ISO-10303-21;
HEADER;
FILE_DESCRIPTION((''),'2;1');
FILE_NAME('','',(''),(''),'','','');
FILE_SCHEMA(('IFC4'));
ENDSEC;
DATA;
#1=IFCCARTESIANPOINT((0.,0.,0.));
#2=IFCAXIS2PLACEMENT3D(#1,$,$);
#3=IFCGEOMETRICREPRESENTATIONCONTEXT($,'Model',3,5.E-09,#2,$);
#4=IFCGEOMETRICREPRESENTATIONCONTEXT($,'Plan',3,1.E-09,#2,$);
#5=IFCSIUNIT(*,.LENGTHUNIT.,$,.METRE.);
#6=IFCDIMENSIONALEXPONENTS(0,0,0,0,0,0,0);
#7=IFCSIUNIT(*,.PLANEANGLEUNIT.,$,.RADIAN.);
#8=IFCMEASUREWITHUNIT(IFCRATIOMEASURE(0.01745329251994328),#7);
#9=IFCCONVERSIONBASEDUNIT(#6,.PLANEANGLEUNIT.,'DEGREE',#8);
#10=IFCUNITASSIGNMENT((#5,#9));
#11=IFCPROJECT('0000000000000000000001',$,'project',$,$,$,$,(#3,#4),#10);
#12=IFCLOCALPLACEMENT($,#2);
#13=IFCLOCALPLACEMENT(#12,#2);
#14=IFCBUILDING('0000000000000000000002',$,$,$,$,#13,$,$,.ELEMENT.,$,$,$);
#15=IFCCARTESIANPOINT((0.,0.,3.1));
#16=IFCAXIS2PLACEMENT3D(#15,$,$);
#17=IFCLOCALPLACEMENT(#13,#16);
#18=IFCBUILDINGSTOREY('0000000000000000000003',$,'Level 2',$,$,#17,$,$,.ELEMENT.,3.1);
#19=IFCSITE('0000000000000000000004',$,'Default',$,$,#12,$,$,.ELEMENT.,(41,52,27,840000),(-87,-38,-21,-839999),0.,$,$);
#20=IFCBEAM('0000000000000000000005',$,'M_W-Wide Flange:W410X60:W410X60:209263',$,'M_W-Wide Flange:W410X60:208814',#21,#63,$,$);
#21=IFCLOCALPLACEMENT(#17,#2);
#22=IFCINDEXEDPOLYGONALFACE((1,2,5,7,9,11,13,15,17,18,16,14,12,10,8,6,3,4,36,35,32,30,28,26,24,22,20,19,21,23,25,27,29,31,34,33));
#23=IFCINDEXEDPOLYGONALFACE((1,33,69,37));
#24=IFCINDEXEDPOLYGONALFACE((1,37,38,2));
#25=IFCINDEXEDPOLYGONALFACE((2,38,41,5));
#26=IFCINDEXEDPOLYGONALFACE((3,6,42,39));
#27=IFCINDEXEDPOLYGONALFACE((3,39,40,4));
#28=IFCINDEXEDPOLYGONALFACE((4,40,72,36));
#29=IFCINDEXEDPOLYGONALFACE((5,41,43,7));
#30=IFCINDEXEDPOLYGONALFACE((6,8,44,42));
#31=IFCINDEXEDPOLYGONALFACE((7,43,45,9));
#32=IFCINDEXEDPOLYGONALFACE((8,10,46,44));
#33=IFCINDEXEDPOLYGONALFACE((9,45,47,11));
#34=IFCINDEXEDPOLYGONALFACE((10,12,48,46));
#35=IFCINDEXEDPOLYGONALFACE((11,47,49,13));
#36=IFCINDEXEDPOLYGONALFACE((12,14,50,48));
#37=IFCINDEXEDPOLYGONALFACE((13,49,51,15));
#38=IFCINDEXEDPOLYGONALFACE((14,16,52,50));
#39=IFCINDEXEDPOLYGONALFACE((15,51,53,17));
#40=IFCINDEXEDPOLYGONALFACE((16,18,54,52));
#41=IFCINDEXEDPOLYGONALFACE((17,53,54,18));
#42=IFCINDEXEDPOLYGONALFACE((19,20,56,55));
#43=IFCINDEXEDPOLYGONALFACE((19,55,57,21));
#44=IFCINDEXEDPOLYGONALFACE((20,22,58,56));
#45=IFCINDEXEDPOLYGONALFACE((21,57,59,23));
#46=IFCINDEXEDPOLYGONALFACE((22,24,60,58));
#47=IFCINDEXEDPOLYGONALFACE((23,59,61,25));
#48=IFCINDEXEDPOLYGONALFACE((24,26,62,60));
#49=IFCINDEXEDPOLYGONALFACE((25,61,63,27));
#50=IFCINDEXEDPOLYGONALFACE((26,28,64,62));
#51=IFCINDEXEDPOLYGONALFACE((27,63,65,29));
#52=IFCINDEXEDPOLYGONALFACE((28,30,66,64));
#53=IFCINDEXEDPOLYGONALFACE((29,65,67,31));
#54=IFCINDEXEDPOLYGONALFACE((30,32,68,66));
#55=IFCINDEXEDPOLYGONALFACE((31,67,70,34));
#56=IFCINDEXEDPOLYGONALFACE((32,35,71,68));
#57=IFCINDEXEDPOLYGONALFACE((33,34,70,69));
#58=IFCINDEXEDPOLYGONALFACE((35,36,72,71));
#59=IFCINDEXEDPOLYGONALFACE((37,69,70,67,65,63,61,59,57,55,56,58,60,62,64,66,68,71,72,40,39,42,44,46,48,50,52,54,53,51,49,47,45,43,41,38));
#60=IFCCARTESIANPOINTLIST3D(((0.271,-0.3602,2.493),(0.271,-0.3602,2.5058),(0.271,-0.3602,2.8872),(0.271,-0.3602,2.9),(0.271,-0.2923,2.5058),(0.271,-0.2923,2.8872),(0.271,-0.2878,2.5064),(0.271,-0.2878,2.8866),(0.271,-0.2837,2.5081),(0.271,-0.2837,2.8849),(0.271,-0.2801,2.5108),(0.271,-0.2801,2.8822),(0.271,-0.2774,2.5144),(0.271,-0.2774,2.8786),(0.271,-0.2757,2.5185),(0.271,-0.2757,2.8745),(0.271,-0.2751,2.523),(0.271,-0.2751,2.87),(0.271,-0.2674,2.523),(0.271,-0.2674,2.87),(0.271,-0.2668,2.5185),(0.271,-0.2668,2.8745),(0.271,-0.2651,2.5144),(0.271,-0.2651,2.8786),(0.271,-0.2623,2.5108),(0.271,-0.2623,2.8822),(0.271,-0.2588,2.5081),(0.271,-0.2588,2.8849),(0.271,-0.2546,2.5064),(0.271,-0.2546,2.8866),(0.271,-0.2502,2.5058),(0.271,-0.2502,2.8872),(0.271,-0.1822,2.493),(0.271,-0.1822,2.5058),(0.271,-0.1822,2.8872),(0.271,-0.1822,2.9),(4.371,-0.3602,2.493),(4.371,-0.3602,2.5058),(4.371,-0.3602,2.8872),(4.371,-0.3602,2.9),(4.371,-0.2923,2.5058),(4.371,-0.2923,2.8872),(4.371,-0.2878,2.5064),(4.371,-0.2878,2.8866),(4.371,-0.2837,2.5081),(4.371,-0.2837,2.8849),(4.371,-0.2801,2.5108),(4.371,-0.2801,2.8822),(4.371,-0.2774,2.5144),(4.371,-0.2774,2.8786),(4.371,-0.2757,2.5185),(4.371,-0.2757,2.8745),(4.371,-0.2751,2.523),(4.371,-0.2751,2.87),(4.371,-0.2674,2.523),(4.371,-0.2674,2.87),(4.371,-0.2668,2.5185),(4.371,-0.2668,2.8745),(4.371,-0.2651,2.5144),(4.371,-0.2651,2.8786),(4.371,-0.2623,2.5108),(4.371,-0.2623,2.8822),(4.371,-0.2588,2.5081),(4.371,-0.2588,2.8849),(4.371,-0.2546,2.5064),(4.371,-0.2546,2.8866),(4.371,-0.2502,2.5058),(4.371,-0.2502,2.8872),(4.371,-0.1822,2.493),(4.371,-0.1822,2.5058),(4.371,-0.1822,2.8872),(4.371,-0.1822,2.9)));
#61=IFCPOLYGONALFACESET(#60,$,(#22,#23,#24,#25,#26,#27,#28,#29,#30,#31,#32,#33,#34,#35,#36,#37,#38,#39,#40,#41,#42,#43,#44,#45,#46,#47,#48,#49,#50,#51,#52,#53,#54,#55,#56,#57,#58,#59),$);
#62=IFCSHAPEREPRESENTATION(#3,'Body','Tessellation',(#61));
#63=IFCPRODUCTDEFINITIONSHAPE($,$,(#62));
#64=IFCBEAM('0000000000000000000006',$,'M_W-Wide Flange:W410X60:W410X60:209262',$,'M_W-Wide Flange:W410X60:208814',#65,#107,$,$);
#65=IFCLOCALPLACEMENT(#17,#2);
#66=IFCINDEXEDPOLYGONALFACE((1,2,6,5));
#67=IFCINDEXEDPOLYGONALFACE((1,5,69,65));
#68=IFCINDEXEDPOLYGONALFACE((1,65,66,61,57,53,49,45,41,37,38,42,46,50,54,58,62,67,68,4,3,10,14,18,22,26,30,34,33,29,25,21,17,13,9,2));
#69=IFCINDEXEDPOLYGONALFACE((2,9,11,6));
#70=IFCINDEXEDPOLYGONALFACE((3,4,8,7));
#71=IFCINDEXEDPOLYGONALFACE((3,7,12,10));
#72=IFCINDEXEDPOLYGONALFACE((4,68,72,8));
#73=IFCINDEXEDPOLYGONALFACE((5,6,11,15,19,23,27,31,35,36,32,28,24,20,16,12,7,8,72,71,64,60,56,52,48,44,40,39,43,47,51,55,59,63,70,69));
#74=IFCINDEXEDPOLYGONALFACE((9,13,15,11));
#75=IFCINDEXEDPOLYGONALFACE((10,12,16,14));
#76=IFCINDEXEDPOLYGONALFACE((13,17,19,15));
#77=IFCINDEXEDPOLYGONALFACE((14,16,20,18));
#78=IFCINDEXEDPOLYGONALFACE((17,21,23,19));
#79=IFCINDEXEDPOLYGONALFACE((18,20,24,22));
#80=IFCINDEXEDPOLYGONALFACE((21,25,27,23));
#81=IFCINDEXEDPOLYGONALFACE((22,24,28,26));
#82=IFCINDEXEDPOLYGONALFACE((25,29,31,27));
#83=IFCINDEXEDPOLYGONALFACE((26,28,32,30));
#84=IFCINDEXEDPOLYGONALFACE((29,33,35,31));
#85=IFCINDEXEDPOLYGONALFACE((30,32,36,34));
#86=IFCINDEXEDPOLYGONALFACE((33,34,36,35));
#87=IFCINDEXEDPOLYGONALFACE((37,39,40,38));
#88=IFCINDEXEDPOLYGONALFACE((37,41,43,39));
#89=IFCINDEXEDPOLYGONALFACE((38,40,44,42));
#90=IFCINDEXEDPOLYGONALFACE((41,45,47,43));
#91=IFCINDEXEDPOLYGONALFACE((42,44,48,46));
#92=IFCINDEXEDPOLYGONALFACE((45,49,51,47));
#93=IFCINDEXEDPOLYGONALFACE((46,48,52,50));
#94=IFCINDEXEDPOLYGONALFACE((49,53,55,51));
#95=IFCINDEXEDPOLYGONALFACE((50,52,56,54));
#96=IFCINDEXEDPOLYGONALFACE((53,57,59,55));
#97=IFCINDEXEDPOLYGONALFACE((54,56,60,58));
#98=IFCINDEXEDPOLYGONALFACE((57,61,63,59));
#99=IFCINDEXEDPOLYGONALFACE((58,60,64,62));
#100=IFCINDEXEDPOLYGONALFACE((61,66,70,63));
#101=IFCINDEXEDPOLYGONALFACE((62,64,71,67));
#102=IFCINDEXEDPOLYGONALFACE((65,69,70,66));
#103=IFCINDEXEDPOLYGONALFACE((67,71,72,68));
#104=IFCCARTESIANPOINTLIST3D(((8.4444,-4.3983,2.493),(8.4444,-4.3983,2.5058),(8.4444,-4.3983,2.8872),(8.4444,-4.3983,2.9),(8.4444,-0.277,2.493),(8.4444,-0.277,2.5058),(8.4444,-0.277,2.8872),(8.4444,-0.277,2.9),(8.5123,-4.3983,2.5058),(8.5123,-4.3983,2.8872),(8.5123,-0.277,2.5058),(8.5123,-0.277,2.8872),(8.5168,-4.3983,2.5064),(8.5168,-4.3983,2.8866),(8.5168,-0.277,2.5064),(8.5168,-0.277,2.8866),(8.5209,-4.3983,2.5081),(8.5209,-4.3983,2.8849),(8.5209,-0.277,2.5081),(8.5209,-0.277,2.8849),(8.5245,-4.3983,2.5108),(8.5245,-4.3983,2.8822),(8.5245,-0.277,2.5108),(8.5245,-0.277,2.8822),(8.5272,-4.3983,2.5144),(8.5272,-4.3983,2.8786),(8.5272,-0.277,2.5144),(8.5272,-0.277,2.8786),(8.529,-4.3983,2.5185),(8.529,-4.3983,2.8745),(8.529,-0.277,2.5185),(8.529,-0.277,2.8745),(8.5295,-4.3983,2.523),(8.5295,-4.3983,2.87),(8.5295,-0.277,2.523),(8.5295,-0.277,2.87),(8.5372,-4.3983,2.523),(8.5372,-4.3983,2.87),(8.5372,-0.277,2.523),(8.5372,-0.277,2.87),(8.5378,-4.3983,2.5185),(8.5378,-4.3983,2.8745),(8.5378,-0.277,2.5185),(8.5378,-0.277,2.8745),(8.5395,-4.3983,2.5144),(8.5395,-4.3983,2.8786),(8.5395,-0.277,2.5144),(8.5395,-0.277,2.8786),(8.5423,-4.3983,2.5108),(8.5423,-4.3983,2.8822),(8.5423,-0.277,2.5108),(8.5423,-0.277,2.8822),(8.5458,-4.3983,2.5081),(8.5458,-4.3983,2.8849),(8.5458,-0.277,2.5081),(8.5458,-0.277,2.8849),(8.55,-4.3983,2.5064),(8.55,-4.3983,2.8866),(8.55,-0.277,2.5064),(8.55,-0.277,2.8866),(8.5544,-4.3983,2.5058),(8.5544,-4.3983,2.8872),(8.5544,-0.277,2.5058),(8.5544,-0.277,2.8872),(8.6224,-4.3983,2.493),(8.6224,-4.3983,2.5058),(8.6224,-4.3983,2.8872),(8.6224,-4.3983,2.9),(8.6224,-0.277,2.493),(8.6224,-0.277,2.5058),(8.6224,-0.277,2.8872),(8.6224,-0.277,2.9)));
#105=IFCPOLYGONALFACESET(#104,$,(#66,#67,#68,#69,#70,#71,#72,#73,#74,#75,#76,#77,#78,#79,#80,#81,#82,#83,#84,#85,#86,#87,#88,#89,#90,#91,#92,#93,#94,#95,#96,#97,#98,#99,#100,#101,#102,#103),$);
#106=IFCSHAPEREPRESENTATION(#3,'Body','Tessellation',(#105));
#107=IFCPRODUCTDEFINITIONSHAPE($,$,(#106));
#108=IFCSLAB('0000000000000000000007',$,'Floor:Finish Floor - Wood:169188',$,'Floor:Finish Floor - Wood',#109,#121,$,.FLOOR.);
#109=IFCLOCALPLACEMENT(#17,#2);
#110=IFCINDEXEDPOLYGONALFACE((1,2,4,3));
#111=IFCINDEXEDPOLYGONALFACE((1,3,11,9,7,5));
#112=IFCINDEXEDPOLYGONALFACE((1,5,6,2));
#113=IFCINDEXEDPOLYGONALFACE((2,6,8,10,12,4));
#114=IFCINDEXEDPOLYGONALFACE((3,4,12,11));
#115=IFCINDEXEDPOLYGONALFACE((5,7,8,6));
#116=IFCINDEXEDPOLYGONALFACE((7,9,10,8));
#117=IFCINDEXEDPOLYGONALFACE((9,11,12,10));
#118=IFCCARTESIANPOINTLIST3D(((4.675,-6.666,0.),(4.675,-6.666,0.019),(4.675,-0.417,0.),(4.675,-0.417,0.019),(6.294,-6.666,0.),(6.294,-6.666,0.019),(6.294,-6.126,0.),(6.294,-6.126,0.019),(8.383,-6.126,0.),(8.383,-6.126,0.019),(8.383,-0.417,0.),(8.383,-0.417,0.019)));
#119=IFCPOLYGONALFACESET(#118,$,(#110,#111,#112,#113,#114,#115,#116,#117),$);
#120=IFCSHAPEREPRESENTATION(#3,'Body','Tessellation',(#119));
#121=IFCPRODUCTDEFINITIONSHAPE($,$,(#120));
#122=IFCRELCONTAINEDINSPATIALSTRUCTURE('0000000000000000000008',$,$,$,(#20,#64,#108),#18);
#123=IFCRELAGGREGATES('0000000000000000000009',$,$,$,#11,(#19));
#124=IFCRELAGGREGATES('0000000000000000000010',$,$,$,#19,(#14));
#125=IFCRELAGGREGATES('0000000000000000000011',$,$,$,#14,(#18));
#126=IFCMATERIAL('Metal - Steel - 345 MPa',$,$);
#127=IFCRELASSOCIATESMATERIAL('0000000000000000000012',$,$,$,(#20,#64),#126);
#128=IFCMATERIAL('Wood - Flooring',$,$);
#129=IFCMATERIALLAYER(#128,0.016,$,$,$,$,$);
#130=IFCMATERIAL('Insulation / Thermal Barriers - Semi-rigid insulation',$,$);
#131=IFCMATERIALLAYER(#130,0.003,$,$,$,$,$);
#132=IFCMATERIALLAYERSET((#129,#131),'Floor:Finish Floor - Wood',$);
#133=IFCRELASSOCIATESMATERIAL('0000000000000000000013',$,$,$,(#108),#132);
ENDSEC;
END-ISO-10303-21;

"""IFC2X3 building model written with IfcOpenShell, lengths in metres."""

from ifc_helpers import new_model, entity, si_unit, converted_unit, frame, frame_2d, origin, place, context, project, spatial, polyline, circle_curve, parameter, trimmed, segment, composite_curve, outline, extrude, material, layer, layer_set, layer_usage, element, save


model = new_model("IFC2X3")

# Units and contexts
model_context = context("Model", 3, precision=5e-09, world=origin())
plan_context = context("Plan", 3, precision=1e-09, world=origin())
ifc_project = project(units=[si_unit("LENGTHUNIT", "METRE"), converted_unit("PLANEANGLEUNIT", "DEGREE", entity("IfcRatioMeasure", 0.01745329251994328), si_unit("PLANEANGLEUNIT", "RADIAN"), dimensions=[0, 0, 0, 0, 0, 0, 0])], contexts=[model_context, plan_context])

# Site, building, storey
site_placement = place(None, origin())
site = spatial("IfcSite", under=ifc_project, at=site_placement, Name="Default", CompositionType="ELEMENT", RefLatitude=(41, 52, 27, 840000), RefLongitude=(-87, -38, -21, -839999), RefElevation=0.0)
building_placement = place(site_placement, origin())
building = spatial("IfcBuilding", under=site, at=building_placement, CompositionType="ELEMENT")
storey_placement = place(building_placement, frame((0.0, 0.0, 3.1)))
storey = spatial("IfcBuildingStorey", under=building, at=storey_placement, Name="Level 2", CompositionType="ELEMENT", Elevation=3.1)

# Beams
ifc_material_1 = material(Name="Metal - Steel - 345 MPa")
beam_1_placement = place(storey_placement, frame((4.371, -0.2712, 2.9), z_axis=(0.0, 0.0, 1.0), x_axis=(0.0, 1.0, 0.0)))
element("IfcBeam", 1, at=beam_1_placement, inside=storey, material=ifc_material_1, Name="M_W-Wide Flange:W410X60:W410X60:209263", ObjectType="M_W-Wide Flange:W410X60:208814", context=model_context, shape_type="SweptSolid", body=[
    extrude(outline(composite_curve([segment(polyline([(0.1907, -0.089), (0.2035, -0.089)]), True, "CONTINUOUS"), segment(polyline([(0.2035, -0.089), (0.2035, 0.089)]), True, "CONTINUOUS"), segment(polyline([(0.2035, 0.089), (0.1907, 0.089)]), True, "CONTINUOUS"), segment(polyline([(0.1907, 0.089), (0.1907, 0.0211)]), True, "CONTINUOUS"), segment(trimmed(circle_curve(frame_2d((0.1735, 0.0211), x_axis=(1.0, 0.0)), 0.0172), [parameter(270.0)], [parameter(360.0)], True, "PARAMETER"), False, "CONTINUOUS"), segment(polyline([(0.1735, 0.0039), (-0.1735, 0.0039)]), True, "CONTINUOUS"), segment(trimmed(circle_curve(frame_2d((-0.1735, 0.0211), x_axis=(0.0, -1.0)), 0.0172), [parameter(270.0)], [parameter(360.0)], True, "PARAMETER"), False, "CONTINUOUS"), segment(polyline([(-0.1907, 0.0211), (-0.1907, 0.089)]), True, "CONTINUOUS"), segment(polyline([(-0.1907, 0.089), (-0.2035, 0.089)]), True, "CONTINUOUS"), segment(polyline([(-0.2035, 0.089), (-0.2035, -0.089)]), True, "CONTINUOUS"), segment(polyline([(-0.2035, -0.089), (-0.1907, -0.089)]), True, "CONTINUOUS"), segment(polyline([(-0.1907, -0.089), (-0.1907, -0.0211)]), True, "CONTINUOUS"), segment(trimmed(circle_curve(frame_2d((-0.1735, -0.0211), x_axis=(-1.0, 0.0)), 0.0172), [parameter(270.0)], [parameter(0.0)], True, "PARAMETER"), False, "CONTINUOUS"), segment(polyline([(-0.1735, -0.0039), (0.1735, -0.0039)]), True, "CONTINUOUS"), segment(trimmed(circle_curve(frame_2d((0.1735, -0.0211), x_axis=(0.0, 1.0)), 0.0172), [parameter(270.0)], [parameter(0.0)], True, "PARAMETER"), False, "CONTINUOUS"), segment(polyline([(0.1907, -0.0211), (0.1907, -0.089)]), True, "CONTINUOUS")], self_intersect=False)), frame((0.0, 4.1, -0.2035), z_axis=(0.0, -1.0, 0.0), x_axis=(0.0, 0.0, -1.0)), (0.0, 0.0, 1.0), 4.1),
])
beam_2_placement = place(storey_placement, frame((8.5334, -4.3983, 2.9)))
element("IfcBeam", 2, at=beam_2_placement, inside=storey, material=ifc_material_1, Name="M_W-Wide Flange:W410X60:W410X60:209262", ObjectType="M_W-Wide Flange:W410X60:208814", context=model_context, shape_type="SweptSolid", body=[
    extrude(outline(composite_curve([segment(polyline([(-0.089, -0.1907), (-0.089, -0.2035)]), True, "CONTINUOUS"), segment(polyline([(-0.089, -0.2035), (0.089, -0.2035)]), True, "CONTINUOUS"), segment(polyline([(0.089, -0.2035), (0.089, -0.1907)]), True, "CONTINUOUS"), segment(polyline([(0.089, -0.1907), (0.021, -0.1907)]), True, "CONTINUOUS"), segment(trimmed(circle_curve(frame_2d((0.021, -0.1735), x_axis=(0.0, -1.0)), 0.0172), [parameter(270.0)], [parameter(360.0)], True, "PARAMETER"), False, "CONTINUOUS"), segment(polyline([(0.0038, -0.1735), (0.0038, 0.1735)]), True, "CONTINUOUS"), segment(trimmed(circle_curve(frame_2d((0.021, 0.1735), x_axis=(-1.0, 0.0)), 0.0172), [parameter(270.0)], [parameter(360.0)], True, "PARAMETER"), False, "CONTINUOUS"), segment(polyline([(0.021, 0.1907), (0.089, 0.1907)]), True, "CONTINUOUS"), segment(polyline([(0.089, 0.1907), (0.089, 0.2035)]), True, "CONTINUOUS"), segment(polyline([(0.089, 0.2035), (-0.089, 0.2035)]), True, "CONTINUOUS"), segment(polyline([(-0.089, 0.2035), (-0.089, 0.1907)]), True, "CONTINUOUS"), segment(polyline([(-0.089, 0.1907), (-0.0211, 0.1907)]), True, "CONTINUOUS"), segment(trimmed(circle_curve(frame_2d((-0.0211, 0.1735), x_axis=(0.0, 1.0)), 0.0172), [parameter(270.0)], [parameter(0.0)], True, "PARAMETER"), False, "CONTINUOUS"), segment(polyline([(-0.0039, 0.1735), (-0.0039, -0.1735)]), True, "CONTINUOUS"), segment(trimmed(circle_curve(frame_2d((-0.0211, -0.1735), x_axis=(1.0, 0.0)), 0.0172), [parameter(270.0)], [parameter(0.0)], True, "PARAMETER"), False, "CONTINUOUS"), segment(polyline([(-0.0211, -0.1907), (-0.089, -0.1907)]), True, "CONTINUOUS")], self_intersect=False)), frame((0.0, 0.0, -0.2035), z_axis=(0.0, -1.0, 0.0), x_axis=(1.0, 0.0, 0.0)), (0.0, 0.0, -1.0), 4.1213),
])

# Slab
ifc_material_2 = material(Name="Wood - Flooring")
ifc_layer_1 = layer(ifc_material_2, 0.016)
ifc_material_3 = material(Name="Insulation / Thermal Barriers - Semi-rigid insulation")
ifc_layer_2 = layer(ifc_material_3, 0.003)
ifc_layer_set_1 = layer_set([ifc_layer_1, ifc_layer_2], Name="Floor:Finish Floor - Wood")
ifc_layer_usage_1 = layer_usage(ifc_layer_set_1, "AXIS3", "POSITIVE", 0.0)
slab_placement = place(storey_placement, frame((4.675, -6.666, 0.0)))
element("IfcSlab", 3, at=slab_placement, inside=storey, material=ifc_layer_usage_1, Name="Floor:Finish Floor - Wood:169188", ObjectType="Floor:Finish Floor - Wood", PredefinedType="FLOOR", context=model_context, shape_type="SweptSolid", body=[
    extrude(outline(polyline([(-1.854, 3.1245), (-1.854, -2.5845), (0.235, -2.5845), (0.235, -3.1245), (1.854, -3.1245), (1.854, 3.1245), (-1.854, 3.1245)])), frame((1.854, 3.1245, 0.019), z_axis=(0.0, 0.0, -1.0), x_axis=(-1.0, 0.0, 0.0)), (0.0, 0.0, 1.0), 0.019),
])

save(model, "model.ifc")
